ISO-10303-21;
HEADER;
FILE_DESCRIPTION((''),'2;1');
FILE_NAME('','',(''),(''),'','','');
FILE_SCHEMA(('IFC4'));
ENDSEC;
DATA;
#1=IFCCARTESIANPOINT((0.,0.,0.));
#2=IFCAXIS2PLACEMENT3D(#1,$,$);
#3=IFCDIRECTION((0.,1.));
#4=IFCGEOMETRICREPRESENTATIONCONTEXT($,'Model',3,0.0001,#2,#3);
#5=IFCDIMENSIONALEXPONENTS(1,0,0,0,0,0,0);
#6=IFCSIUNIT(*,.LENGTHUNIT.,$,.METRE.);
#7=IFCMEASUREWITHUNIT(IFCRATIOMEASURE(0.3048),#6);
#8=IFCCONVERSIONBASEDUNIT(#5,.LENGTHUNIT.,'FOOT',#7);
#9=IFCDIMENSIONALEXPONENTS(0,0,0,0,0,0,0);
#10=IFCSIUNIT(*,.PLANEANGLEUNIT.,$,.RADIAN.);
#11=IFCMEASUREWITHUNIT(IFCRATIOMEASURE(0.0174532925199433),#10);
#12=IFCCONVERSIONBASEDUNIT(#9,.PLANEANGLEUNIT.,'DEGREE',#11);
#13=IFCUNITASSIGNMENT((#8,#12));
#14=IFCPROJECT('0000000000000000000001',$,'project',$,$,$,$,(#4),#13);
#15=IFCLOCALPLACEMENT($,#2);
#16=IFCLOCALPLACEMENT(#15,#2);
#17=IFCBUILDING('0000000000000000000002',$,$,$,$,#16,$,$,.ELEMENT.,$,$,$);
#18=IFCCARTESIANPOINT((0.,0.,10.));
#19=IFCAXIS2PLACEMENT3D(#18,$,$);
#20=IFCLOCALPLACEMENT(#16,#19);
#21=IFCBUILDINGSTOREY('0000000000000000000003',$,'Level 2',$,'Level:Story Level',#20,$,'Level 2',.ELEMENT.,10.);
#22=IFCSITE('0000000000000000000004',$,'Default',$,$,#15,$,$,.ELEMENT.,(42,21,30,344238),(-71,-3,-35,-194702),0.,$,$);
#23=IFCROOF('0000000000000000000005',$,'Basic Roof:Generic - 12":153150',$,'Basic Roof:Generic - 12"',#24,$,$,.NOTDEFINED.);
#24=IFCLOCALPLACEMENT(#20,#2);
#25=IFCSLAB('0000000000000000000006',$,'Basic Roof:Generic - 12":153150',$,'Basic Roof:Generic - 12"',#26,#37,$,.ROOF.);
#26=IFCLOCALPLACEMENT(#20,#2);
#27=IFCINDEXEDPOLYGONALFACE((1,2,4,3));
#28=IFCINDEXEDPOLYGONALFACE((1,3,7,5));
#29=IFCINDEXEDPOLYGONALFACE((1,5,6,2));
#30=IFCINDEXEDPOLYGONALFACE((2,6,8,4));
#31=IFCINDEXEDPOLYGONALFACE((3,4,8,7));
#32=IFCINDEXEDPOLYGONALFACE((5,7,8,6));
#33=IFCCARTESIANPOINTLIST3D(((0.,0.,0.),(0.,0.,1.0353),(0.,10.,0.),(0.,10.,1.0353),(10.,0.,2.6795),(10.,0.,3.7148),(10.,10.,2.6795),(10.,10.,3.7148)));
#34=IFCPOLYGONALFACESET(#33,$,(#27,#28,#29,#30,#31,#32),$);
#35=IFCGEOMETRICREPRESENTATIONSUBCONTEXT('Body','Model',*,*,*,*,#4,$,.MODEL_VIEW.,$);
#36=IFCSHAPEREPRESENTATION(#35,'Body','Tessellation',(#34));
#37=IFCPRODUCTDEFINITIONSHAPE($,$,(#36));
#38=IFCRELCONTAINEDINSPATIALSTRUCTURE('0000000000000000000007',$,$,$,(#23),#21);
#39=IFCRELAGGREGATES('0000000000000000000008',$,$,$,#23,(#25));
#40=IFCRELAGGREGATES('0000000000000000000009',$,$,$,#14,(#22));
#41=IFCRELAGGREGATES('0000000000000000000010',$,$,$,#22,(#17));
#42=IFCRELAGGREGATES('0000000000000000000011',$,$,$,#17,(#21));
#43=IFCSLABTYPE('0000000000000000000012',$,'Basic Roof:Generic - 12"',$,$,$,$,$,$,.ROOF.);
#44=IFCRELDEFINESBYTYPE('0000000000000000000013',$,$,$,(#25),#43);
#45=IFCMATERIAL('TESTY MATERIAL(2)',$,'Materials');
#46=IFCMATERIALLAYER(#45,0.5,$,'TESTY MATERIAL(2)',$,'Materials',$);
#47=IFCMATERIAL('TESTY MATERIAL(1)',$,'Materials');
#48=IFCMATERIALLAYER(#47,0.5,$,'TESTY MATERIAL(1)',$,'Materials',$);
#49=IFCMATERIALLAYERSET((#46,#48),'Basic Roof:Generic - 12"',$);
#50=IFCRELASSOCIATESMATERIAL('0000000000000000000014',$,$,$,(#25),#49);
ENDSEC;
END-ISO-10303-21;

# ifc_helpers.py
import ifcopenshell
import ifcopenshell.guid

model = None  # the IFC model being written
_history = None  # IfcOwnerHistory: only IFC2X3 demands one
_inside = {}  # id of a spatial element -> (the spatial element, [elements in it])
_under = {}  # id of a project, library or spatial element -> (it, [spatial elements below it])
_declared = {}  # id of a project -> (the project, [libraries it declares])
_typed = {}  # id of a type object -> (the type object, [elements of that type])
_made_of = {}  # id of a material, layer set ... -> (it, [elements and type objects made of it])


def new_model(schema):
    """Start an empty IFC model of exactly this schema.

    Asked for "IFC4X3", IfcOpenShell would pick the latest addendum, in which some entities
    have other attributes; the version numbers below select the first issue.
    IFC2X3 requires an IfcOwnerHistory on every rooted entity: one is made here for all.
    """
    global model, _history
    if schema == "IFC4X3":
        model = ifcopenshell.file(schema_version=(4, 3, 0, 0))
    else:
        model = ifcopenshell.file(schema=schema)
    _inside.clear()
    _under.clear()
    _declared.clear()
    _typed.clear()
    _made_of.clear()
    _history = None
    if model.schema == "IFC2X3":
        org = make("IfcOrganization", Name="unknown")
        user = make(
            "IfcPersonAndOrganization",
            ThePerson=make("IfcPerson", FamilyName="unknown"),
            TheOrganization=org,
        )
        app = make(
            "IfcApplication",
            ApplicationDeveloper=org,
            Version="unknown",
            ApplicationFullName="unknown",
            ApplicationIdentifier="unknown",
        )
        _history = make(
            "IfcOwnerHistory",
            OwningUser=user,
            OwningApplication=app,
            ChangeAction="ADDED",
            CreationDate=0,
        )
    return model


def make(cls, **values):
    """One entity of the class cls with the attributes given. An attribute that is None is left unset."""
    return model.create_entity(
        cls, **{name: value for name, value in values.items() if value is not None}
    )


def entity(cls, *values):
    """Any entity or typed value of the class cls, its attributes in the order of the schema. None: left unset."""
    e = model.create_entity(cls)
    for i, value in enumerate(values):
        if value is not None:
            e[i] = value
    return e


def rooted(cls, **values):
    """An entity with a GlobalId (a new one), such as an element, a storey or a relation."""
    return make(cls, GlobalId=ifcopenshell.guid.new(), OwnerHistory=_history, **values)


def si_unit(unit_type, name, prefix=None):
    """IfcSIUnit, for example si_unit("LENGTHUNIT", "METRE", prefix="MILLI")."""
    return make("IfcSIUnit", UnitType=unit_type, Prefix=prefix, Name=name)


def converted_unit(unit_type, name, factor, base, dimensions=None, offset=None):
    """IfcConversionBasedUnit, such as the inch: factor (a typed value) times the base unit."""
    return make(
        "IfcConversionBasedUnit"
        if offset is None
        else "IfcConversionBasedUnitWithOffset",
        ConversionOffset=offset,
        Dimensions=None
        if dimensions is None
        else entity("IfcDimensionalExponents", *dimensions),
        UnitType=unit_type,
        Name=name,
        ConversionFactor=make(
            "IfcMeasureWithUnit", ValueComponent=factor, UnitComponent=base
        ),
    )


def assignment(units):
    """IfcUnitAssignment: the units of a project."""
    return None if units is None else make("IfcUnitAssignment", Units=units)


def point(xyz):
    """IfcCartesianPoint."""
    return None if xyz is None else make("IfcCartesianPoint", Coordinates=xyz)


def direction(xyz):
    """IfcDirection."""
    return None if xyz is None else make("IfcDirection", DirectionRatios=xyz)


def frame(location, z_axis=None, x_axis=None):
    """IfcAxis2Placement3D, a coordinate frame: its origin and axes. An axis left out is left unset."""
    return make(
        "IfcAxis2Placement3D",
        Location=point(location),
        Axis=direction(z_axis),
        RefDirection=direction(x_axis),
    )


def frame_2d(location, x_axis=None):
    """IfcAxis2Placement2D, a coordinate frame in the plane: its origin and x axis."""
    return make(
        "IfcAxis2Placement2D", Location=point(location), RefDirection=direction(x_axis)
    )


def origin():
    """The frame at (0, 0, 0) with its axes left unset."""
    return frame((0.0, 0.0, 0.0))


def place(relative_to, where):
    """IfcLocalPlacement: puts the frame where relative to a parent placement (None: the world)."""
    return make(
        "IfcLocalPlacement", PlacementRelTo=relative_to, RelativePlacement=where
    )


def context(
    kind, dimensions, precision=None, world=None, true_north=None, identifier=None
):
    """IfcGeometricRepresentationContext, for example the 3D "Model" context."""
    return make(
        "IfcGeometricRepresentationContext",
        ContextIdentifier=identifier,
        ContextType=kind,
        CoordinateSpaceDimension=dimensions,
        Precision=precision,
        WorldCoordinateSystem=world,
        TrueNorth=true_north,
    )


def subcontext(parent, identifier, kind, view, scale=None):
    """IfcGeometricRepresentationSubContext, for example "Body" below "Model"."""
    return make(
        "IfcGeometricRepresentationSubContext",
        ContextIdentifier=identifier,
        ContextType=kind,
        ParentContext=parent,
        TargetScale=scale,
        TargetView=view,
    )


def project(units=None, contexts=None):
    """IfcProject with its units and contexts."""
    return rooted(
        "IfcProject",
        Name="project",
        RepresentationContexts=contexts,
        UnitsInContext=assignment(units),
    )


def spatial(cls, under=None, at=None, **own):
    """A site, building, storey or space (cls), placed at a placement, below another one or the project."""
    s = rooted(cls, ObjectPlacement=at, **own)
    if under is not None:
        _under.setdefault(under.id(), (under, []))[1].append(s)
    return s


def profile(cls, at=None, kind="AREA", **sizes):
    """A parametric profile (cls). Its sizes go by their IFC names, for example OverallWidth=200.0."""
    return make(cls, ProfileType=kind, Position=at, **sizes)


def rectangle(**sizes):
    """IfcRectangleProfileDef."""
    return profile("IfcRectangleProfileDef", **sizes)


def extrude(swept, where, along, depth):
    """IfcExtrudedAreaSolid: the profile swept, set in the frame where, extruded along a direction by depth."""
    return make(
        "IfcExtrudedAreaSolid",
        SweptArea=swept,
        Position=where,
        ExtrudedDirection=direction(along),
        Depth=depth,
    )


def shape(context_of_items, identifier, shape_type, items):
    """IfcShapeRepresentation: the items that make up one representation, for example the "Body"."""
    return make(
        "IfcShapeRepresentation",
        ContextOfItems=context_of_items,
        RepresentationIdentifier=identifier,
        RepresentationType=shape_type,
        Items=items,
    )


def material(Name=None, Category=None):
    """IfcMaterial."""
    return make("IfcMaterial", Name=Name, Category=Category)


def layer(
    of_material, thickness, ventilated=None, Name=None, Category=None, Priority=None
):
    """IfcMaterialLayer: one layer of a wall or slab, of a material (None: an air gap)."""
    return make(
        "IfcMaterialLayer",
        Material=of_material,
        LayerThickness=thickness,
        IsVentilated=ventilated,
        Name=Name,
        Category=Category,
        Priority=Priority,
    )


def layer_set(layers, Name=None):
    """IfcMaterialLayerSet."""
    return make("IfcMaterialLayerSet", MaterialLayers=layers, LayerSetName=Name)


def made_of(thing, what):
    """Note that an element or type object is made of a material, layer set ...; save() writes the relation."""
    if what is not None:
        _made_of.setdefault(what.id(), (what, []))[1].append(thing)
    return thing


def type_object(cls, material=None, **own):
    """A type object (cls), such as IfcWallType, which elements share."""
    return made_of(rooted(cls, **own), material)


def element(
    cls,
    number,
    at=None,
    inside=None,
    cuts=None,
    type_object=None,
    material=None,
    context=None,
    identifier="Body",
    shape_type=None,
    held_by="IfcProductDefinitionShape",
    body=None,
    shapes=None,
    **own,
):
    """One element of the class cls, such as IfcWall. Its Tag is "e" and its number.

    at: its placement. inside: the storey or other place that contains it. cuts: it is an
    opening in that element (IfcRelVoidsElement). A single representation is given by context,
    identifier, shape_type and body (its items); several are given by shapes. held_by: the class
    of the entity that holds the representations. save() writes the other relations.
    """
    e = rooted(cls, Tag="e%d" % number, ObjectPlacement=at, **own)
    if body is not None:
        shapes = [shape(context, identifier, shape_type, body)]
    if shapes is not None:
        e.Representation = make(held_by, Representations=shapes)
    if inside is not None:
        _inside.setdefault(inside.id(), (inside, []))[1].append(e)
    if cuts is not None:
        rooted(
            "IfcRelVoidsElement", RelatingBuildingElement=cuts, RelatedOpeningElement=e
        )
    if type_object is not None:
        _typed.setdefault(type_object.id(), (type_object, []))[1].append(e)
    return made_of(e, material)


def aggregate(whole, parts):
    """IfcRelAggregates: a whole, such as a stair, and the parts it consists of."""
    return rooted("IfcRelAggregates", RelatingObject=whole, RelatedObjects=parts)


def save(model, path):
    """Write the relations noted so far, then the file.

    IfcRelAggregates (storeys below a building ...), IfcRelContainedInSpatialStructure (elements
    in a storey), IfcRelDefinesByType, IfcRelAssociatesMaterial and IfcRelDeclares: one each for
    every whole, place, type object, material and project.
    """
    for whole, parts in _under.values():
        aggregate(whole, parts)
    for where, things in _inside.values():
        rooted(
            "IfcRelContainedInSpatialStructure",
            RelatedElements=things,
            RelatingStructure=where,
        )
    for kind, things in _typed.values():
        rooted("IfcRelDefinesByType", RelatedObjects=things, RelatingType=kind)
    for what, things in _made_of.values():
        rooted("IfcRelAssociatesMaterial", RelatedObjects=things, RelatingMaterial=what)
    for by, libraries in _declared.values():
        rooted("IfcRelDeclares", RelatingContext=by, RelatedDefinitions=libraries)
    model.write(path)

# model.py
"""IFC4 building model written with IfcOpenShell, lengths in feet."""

from ifc_helpers import new_model, entity, si_unit, converted_unit, direction, frame, frame_2d, origin, place, context, subcontext, project, spatial, rectangle, extrude, material, layer, layer_set, type_object, element, aggregate, save


model = new_model("IFC4")

# Units and contexts
model_context = context("Model", 3, precision=0.0001, world=origin(), true_north=direction((0.0, 1.0)))
body_context = subcontext(model_context, "Body", "Model", "MODEL_VIEW")
ifc_project = project(units=[converted_unit("LENGTHUNIT", "FOOT", entity("IfcRatioMeasure", 0.3048), si_unit("LENGTHUNIT", "METRE"), dimensions=[1, 0, 0, 0, 0, 0, 0]), converted_unit("PLANEANGLEUNIT", "DEGREE", entity("IfcRatioMeasure", 0.0174532925199433), si_unit("PLANEANGLEUNIT", "RADIAN"), dimensions=[0, 0, 0, 0, 0, 0, 0])], contexts=[model_context])

# Site, building, storey
site_placement = place(None, origin())
site = spatial("IfcSite", under=ifc_project, at=site_placement, Name="Default", CompositionType="ELEMENT", RefLatitude=(42, 21, 30, 344238), RefLongitude=(-71, -3, -35, -194702), RefElevation=0.0)
building_placement = place(site_placement, origin())
building = spatial("IfcBuilding", under=site, at=building_placement, CompositionType="ELEMENT")
storey_placement = place(building_placement, frame((0.0, 0.0, 10.0)))
storey = spatial("IfcBuildingStorey", under=building, at=storey_placement, Name="Level 2", ObjectType="Level:Story Level", LongName="Level 2", CompositionType="ELEMENT", Elevation=10.0)

# Roof, slab
roof_placement = place(storey_placement, origin())
roof = element("IfcRoof", 1, at=roof_placement, inside=storey, Name="Basic Roof:Generic - 12\":153150", ObjectType="Basic Roof:Generic - 12\"", PredefinedType="NOTDEFINED")
ifc_material_1 = material(Name="TESTY MATERIAL(2)", Category="Materials")
ifc_layer_1 = layer(ifc_material_1, 0.5, Name="TESTY MATERIAL(2)", Category="Materials")
ifc_material_2 = material(Name="TESTY MATERIAL(1)", Category="Materials")
ifc_layer_2 = layer(ifc_material_2, 0.5, Name="TESTY MATERIAL(1)", Category="Materials")
ifc_layer_set = layer_set([ifc_layer_1, ifc_layer_2], Name="Basic Roof:Generic - 12\"")
slab_type = type_object("IfcSlabType", Name="Basic Roof:Generic - 12\"", PredefinedType="ROOF")
slab_placement = place(roof_placement, origin())
slab = element("IfcSlab", 2, at=slab_placement, type_object=slab_type, material=ifc_layer_set, Name="Basic Roof:Generic - 12\":153150", ObjectType="Basic Roof:Generic - 12\"", PredefinedType="ROOF", context=body_context, shape_type="SweptSolid", body=[
    extrude(rectangle(XDim=10.3528, YDim=10.0, at=frame_2d((0.0, 0.0), x_axis=(-1.0, 0.0))), frame((5.0, 5.0, 1.3397), z_axis=(-0.258819, 0.0, 0.965926), x_axis=(0.965926, 0.0, 0.258819)), (0.258819, 0.0, 0.965926), 1.0353),
])
aggregate(roof, [slab])

save(model, "model.ifc")
